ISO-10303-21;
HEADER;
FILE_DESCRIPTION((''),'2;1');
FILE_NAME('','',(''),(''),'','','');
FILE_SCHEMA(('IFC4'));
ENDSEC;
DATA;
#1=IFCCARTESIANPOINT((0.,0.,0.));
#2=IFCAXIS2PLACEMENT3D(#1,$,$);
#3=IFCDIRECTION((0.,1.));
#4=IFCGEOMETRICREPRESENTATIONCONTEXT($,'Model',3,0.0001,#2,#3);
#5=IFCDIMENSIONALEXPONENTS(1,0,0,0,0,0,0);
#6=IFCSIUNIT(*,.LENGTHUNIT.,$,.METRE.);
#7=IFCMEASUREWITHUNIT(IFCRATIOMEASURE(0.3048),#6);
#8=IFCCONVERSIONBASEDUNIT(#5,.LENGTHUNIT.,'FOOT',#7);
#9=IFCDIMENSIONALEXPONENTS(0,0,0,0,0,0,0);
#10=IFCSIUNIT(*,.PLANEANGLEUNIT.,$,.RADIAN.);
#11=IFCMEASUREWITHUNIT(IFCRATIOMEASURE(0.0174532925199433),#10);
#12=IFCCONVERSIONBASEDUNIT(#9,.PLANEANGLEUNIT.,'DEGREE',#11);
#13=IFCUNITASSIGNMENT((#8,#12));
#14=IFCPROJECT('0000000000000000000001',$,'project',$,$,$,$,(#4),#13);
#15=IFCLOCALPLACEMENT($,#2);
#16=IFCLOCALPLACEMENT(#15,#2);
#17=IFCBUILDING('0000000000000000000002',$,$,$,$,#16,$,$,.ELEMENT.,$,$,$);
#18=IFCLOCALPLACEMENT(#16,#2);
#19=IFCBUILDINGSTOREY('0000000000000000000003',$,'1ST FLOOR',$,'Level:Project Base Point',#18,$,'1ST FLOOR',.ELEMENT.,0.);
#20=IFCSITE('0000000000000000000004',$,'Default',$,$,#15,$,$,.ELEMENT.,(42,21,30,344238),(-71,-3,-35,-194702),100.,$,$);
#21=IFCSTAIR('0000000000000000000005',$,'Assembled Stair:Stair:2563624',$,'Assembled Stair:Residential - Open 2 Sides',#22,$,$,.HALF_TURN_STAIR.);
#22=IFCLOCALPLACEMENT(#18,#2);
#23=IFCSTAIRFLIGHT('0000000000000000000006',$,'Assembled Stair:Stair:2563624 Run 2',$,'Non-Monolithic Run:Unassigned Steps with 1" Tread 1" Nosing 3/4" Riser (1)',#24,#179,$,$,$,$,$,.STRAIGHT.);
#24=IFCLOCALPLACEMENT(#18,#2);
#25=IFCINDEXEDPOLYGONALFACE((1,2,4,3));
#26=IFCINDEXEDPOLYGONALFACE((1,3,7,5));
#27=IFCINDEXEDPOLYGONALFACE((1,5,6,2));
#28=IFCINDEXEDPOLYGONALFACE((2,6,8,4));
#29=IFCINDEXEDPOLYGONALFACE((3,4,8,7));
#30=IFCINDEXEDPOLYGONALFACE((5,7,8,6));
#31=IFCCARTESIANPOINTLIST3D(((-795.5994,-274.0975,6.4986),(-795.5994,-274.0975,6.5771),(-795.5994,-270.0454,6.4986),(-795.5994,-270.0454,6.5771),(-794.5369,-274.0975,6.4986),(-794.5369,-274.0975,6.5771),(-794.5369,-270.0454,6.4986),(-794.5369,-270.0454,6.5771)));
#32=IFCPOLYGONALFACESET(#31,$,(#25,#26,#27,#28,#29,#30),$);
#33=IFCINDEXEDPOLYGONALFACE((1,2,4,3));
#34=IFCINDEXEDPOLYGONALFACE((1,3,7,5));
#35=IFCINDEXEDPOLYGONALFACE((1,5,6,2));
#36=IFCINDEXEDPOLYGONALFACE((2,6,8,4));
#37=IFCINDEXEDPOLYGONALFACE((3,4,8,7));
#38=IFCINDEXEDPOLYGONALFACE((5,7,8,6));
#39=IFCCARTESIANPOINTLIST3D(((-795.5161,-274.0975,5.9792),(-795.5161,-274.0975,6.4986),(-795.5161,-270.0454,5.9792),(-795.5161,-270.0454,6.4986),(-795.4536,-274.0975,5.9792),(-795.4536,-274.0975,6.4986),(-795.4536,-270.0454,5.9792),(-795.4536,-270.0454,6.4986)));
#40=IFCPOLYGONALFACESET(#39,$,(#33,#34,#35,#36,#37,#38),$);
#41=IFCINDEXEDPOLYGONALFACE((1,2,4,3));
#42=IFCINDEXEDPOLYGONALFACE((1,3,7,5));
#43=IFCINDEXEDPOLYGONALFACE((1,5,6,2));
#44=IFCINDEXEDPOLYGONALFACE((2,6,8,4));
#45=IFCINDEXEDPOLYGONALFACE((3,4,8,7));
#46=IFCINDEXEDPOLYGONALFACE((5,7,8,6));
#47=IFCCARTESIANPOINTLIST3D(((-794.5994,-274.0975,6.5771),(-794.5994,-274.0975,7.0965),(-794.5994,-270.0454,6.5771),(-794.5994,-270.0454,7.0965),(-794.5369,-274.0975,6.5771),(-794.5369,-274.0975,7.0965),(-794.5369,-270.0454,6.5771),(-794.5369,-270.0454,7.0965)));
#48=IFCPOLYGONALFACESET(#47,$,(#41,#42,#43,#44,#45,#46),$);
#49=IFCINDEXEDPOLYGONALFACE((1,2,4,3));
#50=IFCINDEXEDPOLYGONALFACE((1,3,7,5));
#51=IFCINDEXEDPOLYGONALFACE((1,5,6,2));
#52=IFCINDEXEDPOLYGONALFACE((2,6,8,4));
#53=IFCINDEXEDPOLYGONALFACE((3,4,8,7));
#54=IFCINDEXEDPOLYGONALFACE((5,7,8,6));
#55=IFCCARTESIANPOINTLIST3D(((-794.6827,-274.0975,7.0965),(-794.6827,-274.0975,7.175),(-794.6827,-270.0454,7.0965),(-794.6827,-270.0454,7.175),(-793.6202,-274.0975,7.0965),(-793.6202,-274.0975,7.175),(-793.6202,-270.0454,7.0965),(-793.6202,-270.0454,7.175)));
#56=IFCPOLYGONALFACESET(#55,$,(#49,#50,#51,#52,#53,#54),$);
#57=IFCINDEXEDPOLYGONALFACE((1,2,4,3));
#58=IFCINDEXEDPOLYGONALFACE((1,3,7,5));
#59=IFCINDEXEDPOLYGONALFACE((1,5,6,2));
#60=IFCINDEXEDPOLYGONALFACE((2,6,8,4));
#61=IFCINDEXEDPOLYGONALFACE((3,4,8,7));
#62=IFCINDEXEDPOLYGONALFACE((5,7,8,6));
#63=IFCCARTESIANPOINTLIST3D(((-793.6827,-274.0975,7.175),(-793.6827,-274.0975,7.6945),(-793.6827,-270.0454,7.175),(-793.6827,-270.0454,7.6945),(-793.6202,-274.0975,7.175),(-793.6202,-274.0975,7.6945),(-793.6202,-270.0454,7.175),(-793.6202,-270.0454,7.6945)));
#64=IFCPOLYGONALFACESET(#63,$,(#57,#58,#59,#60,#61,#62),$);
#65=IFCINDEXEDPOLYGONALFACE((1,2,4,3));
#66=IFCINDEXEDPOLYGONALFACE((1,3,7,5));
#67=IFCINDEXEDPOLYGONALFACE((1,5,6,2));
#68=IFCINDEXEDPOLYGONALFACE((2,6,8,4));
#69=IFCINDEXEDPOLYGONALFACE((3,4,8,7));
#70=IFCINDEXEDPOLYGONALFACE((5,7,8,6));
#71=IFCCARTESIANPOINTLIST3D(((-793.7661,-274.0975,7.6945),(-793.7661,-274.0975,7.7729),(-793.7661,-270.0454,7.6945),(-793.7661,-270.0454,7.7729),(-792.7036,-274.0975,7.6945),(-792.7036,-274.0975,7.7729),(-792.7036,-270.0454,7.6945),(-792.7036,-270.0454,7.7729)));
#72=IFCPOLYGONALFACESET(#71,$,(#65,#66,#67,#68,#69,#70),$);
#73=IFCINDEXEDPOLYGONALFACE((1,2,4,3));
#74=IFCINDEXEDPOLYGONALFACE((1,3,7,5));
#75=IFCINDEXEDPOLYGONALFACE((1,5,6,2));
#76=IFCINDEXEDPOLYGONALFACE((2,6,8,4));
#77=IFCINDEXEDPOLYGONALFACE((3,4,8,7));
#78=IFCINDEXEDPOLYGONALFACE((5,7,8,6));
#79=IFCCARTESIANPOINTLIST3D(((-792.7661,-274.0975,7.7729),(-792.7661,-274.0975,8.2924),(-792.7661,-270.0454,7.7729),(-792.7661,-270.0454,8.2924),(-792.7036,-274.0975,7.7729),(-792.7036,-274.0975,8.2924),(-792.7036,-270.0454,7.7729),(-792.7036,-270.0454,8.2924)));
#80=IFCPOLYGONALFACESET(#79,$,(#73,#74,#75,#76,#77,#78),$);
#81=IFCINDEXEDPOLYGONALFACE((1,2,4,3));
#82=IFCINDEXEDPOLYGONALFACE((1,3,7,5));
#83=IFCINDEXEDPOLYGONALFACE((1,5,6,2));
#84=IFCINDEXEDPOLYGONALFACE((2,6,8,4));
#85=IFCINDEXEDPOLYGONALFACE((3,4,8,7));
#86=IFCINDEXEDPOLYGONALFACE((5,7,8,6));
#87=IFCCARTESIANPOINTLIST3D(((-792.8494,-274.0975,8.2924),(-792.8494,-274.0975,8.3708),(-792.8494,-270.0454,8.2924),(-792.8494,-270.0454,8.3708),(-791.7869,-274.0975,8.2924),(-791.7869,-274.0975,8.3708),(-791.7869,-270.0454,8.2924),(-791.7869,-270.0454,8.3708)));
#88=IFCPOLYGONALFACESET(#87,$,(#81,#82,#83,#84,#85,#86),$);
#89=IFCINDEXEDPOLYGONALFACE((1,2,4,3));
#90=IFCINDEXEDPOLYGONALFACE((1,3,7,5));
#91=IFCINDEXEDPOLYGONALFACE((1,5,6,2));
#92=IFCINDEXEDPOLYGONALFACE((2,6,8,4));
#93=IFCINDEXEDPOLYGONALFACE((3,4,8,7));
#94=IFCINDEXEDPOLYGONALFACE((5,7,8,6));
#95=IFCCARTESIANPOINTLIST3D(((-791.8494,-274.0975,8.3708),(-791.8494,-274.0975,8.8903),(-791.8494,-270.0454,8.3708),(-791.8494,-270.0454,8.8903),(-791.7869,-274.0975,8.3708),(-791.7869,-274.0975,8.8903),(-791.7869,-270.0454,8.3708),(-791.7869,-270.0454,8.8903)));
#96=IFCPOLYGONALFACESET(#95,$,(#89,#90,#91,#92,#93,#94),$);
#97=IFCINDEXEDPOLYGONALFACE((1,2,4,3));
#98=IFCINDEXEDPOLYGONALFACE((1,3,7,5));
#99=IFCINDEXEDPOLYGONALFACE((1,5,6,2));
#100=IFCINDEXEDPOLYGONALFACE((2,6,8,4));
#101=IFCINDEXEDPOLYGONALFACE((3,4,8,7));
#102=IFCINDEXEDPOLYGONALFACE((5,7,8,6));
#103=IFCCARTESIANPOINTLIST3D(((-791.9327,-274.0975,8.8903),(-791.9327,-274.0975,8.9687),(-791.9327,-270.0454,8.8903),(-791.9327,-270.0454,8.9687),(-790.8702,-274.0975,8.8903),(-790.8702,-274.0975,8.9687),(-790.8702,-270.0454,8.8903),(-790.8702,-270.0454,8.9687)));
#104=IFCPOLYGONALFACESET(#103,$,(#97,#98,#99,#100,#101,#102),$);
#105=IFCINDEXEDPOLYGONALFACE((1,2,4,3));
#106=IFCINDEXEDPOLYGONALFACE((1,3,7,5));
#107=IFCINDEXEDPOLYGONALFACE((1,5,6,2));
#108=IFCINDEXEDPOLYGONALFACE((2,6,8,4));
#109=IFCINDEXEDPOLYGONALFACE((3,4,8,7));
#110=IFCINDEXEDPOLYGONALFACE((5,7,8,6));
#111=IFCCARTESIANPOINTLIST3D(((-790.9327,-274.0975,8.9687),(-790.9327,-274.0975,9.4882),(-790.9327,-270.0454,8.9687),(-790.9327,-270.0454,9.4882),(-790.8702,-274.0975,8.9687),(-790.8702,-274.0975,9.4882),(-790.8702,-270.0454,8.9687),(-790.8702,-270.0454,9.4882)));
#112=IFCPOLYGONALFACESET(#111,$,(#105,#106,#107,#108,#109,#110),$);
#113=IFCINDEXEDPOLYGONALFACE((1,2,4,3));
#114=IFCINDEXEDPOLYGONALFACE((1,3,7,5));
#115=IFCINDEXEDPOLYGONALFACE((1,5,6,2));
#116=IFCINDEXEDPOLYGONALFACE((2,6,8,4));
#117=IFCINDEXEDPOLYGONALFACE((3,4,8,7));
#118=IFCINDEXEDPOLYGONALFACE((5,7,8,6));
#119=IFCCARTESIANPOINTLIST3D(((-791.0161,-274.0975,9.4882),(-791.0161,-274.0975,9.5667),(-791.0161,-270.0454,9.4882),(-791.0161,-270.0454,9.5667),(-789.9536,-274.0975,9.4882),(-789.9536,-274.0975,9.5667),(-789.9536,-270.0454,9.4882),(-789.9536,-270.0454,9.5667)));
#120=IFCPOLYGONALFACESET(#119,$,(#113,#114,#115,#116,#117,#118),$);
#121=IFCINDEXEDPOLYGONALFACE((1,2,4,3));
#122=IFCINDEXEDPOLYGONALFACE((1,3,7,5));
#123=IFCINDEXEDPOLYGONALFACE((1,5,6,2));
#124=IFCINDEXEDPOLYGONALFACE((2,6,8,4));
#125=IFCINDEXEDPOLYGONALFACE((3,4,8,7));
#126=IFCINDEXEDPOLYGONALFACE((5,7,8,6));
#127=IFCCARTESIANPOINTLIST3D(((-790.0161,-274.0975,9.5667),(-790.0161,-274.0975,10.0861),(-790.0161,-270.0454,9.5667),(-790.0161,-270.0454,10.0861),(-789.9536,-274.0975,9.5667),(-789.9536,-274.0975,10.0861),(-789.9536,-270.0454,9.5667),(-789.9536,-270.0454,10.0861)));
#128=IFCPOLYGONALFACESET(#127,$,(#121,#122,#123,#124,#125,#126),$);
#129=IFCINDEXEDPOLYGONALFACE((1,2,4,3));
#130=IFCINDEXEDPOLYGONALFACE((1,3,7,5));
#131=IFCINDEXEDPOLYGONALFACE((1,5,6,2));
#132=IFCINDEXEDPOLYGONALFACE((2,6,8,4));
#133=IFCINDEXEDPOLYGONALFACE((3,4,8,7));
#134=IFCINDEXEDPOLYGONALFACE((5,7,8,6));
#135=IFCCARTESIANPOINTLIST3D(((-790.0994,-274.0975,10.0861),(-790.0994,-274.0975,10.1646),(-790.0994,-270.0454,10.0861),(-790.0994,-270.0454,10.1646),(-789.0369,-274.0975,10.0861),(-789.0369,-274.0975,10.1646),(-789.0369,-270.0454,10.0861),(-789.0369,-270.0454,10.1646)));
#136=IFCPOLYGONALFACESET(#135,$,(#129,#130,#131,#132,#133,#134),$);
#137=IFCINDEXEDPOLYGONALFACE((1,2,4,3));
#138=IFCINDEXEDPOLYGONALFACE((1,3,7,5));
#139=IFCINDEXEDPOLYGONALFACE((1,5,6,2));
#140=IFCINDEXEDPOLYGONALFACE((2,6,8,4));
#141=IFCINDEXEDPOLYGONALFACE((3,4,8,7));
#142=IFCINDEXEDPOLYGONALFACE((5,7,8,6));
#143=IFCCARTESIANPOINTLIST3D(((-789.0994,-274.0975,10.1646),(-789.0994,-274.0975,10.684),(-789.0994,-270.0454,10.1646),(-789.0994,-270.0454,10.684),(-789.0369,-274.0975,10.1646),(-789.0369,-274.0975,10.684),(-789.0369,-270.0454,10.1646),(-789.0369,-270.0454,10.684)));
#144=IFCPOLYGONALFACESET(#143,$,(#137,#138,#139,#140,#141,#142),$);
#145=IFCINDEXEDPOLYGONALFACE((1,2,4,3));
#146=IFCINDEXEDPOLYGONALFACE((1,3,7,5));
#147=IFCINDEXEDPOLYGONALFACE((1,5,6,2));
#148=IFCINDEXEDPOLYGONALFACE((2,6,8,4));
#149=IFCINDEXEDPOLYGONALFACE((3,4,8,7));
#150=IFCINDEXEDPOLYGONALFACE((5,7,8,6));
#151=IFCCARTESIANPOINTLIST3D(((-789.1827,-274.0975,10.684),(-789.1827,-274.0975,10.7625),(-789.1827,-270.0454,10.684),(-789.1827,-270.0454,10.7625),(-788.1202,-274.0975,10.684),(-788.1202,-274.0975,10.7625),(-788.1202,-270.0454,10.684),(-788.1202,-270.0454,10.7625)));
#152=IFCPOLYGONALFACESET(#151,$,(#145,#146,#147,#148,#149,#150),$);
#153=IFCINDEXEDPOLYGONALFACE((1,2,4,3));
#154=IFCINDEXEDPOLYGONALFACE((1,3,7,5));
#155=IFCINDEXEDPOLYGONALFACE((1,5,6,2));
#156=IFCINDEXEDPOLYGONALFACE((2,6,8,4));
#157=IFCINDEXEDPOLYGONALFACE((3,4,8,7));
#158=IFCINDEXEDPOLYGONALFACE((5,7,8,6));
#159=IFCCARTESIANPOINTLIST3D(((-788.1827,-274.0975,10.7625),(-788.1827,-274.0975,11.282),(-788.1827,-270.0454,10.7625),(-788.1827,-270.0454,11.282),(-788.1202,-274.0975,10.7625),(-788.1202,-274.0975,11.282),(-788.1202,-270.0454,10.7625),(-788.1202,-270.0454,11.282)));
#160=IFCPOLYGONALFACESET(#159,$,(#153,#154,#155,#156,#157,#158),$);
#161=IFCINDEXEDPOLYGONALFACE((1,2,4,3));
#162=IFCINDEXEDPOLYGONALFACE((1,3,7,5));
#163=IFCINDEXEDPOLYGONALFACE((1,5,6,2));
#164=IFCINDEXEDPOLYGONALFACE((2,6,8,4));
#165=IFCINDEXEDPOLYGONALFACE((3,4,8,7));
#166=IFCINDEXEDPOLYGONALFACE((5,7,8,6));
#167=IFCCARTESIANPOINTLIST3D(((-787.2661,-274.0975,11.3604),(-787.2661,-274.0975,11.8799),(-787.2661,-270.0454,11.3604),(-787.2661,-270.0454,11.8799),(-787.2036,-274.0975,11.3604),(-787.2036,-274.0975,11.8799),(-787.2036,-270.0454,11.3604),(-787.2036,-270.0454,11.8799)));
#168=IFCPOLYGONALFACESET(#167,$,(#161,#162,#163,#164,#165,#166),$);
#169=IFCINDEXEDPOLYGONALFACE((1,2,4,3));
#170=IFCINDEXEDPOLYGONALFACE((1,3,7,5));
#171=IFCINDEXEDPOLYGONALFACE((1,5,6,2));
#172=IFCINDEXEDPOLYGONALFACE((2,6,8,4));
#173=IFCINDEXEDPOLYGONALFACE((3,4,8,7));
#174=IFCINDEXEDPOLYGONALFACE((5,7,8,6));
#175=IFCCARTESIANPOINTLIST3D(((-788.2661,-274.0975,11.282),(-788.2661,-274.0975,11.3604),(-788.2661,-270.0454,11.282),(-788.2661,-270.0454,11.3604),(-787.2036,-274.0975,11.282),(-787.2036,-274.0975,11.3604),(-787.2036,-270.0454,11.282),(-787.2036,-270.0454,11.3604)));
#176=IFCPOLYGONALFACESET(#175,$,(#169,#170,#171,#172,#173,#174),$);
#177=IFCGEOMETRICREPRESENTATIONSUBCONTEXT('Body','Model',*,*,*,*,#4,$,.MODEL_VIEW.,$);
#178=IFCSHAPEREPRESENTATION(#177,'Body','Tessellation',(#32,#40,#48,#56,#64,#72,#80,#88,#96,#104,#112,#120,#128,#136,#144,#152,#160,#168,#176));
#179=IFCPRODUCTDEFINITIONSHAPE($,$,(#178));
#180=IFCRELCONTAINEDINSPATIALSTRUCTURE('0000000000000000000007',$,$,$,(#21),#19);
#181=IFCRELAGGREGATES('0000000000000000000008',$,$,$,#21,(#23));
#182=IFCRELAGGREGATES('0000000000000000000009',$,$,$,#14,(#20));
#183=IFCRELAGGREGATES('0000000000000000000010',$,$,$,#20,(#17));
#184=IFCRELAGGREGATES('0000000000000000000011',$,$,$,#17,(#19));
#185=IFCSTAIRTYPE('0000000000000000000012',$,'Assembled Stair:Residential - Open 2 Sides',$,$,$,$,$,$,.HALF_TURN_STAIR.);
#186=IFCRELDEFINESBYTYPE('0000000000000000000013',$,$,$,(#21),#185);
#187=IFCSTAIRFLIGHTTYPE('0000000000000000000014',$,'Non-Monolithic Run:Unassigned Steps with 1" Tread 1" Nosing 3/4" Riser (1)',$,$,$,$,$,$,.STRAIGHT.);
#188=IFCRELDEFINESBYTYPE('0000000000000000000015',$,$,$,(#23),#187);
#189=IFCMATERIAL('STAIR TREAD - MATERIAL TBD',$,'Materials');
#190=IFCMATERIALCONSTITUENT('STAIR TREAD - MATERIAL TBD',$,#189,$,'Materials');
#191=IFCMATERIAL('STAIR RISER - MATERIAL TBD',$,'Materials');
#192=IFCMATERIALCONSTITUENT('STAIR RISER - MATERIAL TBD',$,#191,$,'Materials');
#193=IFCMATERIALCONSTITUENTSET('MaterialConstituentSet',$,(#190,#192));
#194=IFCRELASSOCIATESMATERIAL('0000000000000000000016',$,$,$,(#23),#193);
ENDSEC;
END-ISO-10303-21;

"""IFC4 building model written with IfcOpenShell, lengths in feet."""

from ifc_helpers import new_model, entity, si_unit, converted_unit, direction, frame, frame_2d, origin, origin_2d_with_axis, place, context, subcontext, project, spatial, rectangle, extrude, material, constituent, constituent_set, type_object, element, aggregate, save


model = new_model("IFC4")

# Units and contexts
model_context = context("Model", 3, precision=0.0001, world=origin(), true_north=direction((0.0, 1.0)))
body_context = subcontext(model_context, "Body", "Model", "MODEL_VIEW")
ifc_project = project(units=[converted_unit("LENGTHUNIT", "FOOT", entity("IfcRatioMeasure", 0.3048), si_unit("LENGTHUNIT", "METRE"), dimensions=[1, 0, 0, 0, 0, 0, 0]), converted_unit("PLANEANGLEUNIT", "DEGREE", entity("IfcRatioMeasure", 0.0174532925199433), si_unit("PLANEANGLEUNIT", "RADIAN"), dimensions=[0, 0, 0, 0, 0, 0, 0])], contexts=[model_context])

# Site, building, storey
site_placement = place(None, origin())
site = spatial("IfcSite", under=ifc_project, at=site_placement, Name="Default", CompositionType="ELEMENT", RefLatitude=(42, 21, 30, 344238), RefLongitude=(-71, -3, -35, -194702), RefElevation=100.0)
building_placement = place(site_placement, origin())
building = spatial("IfcBuilding", under=site, at=building_placement, CompositionType="ELEMENT")
storey_placement = place(building_placement, origin())
storey = spatial("IfcBuildingStorey", under=building, at=storey_placement, Name="1ST FLOOR", ObjectType="Level:Project Base Point", LongName="1ST FLOOR", CompositionType="ELEMENT", Elevation=0.0)

# Stair
stair_type_1 = type_object("IfcStairType", Name="Assembled Stair:Residential - Open 2 Sides", PredefinedType="HALF_TURN_STAIR")
stair_1_placement = place(storey_placement, origin())
stair_1 = element("IfcStair", 1, at=stair_1_placement, inside=storey, type_object=stair_type_1, Name="Assembled Stair:Stair:2563624", ObjectType="Assembled Stair:Residential - Open 2 Sides", PredefinedType="HALF_TURN_STAIR")

# Shared definitions
ifc_material_1 = material(Name="STAIR TREAD - MATERIAL TBD", Category="Materials")

# Stair flight
ifc_material_2 = material(Name="STAIR RISER - MATERIAL TBD", Category="Materials")
ifc_constituent_1 = constituent(ifc_material_1, Name="STAIR TREAD - MATERIAL TBD", Category="Materials")
ifc_constituent_2 = constituent(ifc_material_2, Name="STAIR RISER - MATERIAL TBD", Category="Materials")
ifc_constituent_set_1 = constituent_set(constituents=[ifc_constituent_1, ifc_constituent_2], Name="MaterialConstituentSet")
stair_flight_type_1 = type_object("IfcStairFlightType", Name="Non-Monolithic Run:Unassigned Steps with 1\" Tread 1\" Nosing 3/4\" Riser (1)", PredefinedType="STRAIGHT")
stair_flight_1_placement = place(stair_1_placement, frame((-795.5994, -274.0975, 0.0)))
stair_flight_1 = element("IfcStairFlight", 2, at=stair_flight_1_placement, type_object=stair_flight_type_1, material=ifc_constituent_set_1, Name="Assembled Stair:Stair:2563624 Run 2", ObjectType="Non-Monolithic Run:Unassigned Steps with 1\" Tread 1\" Nosing 3/4\" Riser (1)", PredefinedType="STRAIGHT", context=body_context, shape_type="SweptSolid", body=[
    extrude(rectangle(XDim=1.0625, YDim=4.0521, at=frame_2d((0.0, 0.0), x_axis=(1.0, 0.0))), frame((0.5312, 2.026, 6.4986), z_axis=(0.0, 0.0, 1.0), x_axis=(-1.0, 0.0, 0.0)), (0.0, 0.0, 1.0), 0.0785),
    extrude(rectangle(XDim=4.0521, YDim=0.0625, at=origin_2d_with_axis()), frame((0.1146, 2.026, 5.9792), z_axis=(0.0, 0.0, 1.0), x_axis=(0.0, 1.0, 0.0)), (0.0, 0.0, 1.0), 0.5195),
    extrude(rectangle(XDim=4.0521, YDim=0.0625, at=frame_2d((0.0, 0.0), x_axis=(1.0, 0.0))), frame((1.0312, 2.026, 6.5771), z_axis=(0.0, 0.0, 1.0), x_axis=(0.0, 1.0, 0.0)), (0.0, 0.0, 1.0), 0.5195),
    extrude(rectangle(XDim=1.0625, YDim=4.0521, at=frame_2d((0.0, 0.0), x_axis=(1.0, 0.0))), frame((1.4479, 2.026, 7.0965), z_axis=(0.0, 0.0, 1.0), x_axis=(-1.0, 0.0, 0.0)), (0.0, 0.0, 1.0), 0.0785),
    extrude(rectangle(XDim=4.0521, YDim=0.0625, at=frame_2d((0.0, 0.0), x_axis=(1.0, 0.0))), frame((1.9479, 2.026, 7.175), z_axis=(0.0, 0.0, 1.0), x_axis=(0.0, 1.0, 0.0)), (0.0, 0.0, 1.0), 0.5195),
    extrude(rectangle(XDim=1.0625, YDim=4.0521, at=frame_2d((0.0, 0.0), x_axis=(1.0, 0.0))), frame((2.3646, 2.026, 7.6945), z_axis=(0.0, 0.0, 1.0), x_axis=(-1.0, 0.0, 0.0)), (0.0, 0.0, 1.0), 0.0785),
    extrude(rectangle(XDim=4.0521, YDim=0.0625, at=origin_2d_with_axis()), frame((2.8646, 2.026, 7.7729), z_axis=(0.0, 0.0, 1.0), x_axis=(0.0, 1.0, 0.0)), (0.0, 0.0, 1.0), 0.5195),
    extrude(rectangle(XDim=1.0625, YDim=4.0521, at=frame_2d((0.0, 0.0), x_axis=(1.0, 0.0))), frame((3.2812, 2.026, 8.2924), z_axis=(0.0, 0.0, 1.0), x_axis=(-1.0, 0.0, 0.0)), (0.0, 0.0, 1.0), 0.0785),
    extrude(rectangle(XDim=4.0521, YDim=0.0625, at=frame_2d((0.0, 0.0), x_axis=(1.0, 0.0))), frame((3.7812, 2.026, 8.3708), z_axis=(0.0, 0.0, 1.0), x_axis=(0.0, 1.0, 0.0)), (0.0, 0.0, 1.0), 0.5195),
    extrude(rectangle(XDim=1.0625, YDim=4.0521, at=frame_2d((0.0, 0.0), x_axis=(1.0, 0.0))), frame((4.1979, 2.026, 8.8903), z_axis=(0.0, 0.0, 1.0), x_axis=(-1.0, 0.0, 0.0)), (0.0, 0.0, 1.0), 0.0785),
    extrude(rectangle(XDim=4.0521, YDim=0.0625, at=frame_2d((0.0, 0.0), x_axis=(1.0, 0.0))), frame((4.6979, 2.026, 8.9687), z_axis=(0.0, 0.0, 1.0), x_axis=(0.0, 1.0, 0.0)), (0.0, 0.0, 1.0), 0.5195),
    extrude(rectangle(XDim=1.0625, YDim=4.0521, at=frame_2d((0.0, 0.0), x_axis=(1.0, 0.0))), frame((5.1146, 2.026, 9.4882), z_axis=(0.0, 0.0, 1.0), x_axis=(-1.0, 0.0, 0.0)), (0.0, 0.0, 1.0), 0.0785),
    extrude(rectangle(XDim=4.0521, YDim=0.0625, at=origin_2d_with_axis()), frame((5.6146, 2.026, 9.5667), z_axis=(0.0, 0.0, 1.0), x_axis=(0.0, 1.0, 0.0)), (0.0, 0.0, 1.0), 0.5195),
    extrude(rectangle(XDim=1.0625, YDim=4.0521, at=frame_2d((0.0, 0.0), x_axis=(1.0, 0.0))), frame((6.0312, 2.026, 10.0861), z_axis=(0.0, 0.0, 1.0), x_axis=(-1.0, 0.0, 0.0)), (0.0, 0.0, 1.0), 0.0785),
    extrude(rectangle(XDim=4.0521, YDim=0.0625, at=origin_2d_with_axis()), frame((6.5312, 2.026, 10.1646), z_axis=(0.0, 0.0, 1.0), x_axis=(0.0, 1.0, 0.0)), (0.0, 0.0, 1.0), 0.5195),
    extrude(rectangle(XDim=1.0625, YDim=4.0521, at=frame_2d((0.0, 0.0), x_axis=(1.0, 0.0))), frame((6.9479, 2.026, 10.684), z_axis=(0.0, 0.0, 1.0), x_axis=(-1.0, 0.0, 0.0)), (0.0, 0.0, 1.0), 0.0785),
    extrude(rectangle(XDim=4.0521, YDim=0.0625, at=origin_2d_with_axis()), frame((7.4479, 2.026, 10.7625), z_axis=(0.0, 0.0, 1.0), x_axis=(0.0, 1.0, 0.0)), (0.0, 0.0, 1.0), 0.5195),
    extrude(rectangle(XDim=4.0521, YDim=0.0625, at=origin_2d_with_axis()), frame((8.3646, 2.026, 11.3604), z_axis=(0.0, 0.0, 1.0), x_axis=(0.0, 1.0, 0.0)), (0.0, 0.0, 1.0), 0.5195),
    extrude(rectangle(XDim=1.0625, YDim=4.0521, at=frame_2d((0.0, 0.0), x_axis=(1.0, 0.0))), frame((7.8646, 2.026, 11.282), z_axis=(0.0, 0.0, 1.0), x_axis=(-1.0, 0.0, 0.0)), (0.0, 0.0, 1.0), 0.0785),
])
aggregate(stair_1, [stair_flight_1])

save(model, "model.ifc")
